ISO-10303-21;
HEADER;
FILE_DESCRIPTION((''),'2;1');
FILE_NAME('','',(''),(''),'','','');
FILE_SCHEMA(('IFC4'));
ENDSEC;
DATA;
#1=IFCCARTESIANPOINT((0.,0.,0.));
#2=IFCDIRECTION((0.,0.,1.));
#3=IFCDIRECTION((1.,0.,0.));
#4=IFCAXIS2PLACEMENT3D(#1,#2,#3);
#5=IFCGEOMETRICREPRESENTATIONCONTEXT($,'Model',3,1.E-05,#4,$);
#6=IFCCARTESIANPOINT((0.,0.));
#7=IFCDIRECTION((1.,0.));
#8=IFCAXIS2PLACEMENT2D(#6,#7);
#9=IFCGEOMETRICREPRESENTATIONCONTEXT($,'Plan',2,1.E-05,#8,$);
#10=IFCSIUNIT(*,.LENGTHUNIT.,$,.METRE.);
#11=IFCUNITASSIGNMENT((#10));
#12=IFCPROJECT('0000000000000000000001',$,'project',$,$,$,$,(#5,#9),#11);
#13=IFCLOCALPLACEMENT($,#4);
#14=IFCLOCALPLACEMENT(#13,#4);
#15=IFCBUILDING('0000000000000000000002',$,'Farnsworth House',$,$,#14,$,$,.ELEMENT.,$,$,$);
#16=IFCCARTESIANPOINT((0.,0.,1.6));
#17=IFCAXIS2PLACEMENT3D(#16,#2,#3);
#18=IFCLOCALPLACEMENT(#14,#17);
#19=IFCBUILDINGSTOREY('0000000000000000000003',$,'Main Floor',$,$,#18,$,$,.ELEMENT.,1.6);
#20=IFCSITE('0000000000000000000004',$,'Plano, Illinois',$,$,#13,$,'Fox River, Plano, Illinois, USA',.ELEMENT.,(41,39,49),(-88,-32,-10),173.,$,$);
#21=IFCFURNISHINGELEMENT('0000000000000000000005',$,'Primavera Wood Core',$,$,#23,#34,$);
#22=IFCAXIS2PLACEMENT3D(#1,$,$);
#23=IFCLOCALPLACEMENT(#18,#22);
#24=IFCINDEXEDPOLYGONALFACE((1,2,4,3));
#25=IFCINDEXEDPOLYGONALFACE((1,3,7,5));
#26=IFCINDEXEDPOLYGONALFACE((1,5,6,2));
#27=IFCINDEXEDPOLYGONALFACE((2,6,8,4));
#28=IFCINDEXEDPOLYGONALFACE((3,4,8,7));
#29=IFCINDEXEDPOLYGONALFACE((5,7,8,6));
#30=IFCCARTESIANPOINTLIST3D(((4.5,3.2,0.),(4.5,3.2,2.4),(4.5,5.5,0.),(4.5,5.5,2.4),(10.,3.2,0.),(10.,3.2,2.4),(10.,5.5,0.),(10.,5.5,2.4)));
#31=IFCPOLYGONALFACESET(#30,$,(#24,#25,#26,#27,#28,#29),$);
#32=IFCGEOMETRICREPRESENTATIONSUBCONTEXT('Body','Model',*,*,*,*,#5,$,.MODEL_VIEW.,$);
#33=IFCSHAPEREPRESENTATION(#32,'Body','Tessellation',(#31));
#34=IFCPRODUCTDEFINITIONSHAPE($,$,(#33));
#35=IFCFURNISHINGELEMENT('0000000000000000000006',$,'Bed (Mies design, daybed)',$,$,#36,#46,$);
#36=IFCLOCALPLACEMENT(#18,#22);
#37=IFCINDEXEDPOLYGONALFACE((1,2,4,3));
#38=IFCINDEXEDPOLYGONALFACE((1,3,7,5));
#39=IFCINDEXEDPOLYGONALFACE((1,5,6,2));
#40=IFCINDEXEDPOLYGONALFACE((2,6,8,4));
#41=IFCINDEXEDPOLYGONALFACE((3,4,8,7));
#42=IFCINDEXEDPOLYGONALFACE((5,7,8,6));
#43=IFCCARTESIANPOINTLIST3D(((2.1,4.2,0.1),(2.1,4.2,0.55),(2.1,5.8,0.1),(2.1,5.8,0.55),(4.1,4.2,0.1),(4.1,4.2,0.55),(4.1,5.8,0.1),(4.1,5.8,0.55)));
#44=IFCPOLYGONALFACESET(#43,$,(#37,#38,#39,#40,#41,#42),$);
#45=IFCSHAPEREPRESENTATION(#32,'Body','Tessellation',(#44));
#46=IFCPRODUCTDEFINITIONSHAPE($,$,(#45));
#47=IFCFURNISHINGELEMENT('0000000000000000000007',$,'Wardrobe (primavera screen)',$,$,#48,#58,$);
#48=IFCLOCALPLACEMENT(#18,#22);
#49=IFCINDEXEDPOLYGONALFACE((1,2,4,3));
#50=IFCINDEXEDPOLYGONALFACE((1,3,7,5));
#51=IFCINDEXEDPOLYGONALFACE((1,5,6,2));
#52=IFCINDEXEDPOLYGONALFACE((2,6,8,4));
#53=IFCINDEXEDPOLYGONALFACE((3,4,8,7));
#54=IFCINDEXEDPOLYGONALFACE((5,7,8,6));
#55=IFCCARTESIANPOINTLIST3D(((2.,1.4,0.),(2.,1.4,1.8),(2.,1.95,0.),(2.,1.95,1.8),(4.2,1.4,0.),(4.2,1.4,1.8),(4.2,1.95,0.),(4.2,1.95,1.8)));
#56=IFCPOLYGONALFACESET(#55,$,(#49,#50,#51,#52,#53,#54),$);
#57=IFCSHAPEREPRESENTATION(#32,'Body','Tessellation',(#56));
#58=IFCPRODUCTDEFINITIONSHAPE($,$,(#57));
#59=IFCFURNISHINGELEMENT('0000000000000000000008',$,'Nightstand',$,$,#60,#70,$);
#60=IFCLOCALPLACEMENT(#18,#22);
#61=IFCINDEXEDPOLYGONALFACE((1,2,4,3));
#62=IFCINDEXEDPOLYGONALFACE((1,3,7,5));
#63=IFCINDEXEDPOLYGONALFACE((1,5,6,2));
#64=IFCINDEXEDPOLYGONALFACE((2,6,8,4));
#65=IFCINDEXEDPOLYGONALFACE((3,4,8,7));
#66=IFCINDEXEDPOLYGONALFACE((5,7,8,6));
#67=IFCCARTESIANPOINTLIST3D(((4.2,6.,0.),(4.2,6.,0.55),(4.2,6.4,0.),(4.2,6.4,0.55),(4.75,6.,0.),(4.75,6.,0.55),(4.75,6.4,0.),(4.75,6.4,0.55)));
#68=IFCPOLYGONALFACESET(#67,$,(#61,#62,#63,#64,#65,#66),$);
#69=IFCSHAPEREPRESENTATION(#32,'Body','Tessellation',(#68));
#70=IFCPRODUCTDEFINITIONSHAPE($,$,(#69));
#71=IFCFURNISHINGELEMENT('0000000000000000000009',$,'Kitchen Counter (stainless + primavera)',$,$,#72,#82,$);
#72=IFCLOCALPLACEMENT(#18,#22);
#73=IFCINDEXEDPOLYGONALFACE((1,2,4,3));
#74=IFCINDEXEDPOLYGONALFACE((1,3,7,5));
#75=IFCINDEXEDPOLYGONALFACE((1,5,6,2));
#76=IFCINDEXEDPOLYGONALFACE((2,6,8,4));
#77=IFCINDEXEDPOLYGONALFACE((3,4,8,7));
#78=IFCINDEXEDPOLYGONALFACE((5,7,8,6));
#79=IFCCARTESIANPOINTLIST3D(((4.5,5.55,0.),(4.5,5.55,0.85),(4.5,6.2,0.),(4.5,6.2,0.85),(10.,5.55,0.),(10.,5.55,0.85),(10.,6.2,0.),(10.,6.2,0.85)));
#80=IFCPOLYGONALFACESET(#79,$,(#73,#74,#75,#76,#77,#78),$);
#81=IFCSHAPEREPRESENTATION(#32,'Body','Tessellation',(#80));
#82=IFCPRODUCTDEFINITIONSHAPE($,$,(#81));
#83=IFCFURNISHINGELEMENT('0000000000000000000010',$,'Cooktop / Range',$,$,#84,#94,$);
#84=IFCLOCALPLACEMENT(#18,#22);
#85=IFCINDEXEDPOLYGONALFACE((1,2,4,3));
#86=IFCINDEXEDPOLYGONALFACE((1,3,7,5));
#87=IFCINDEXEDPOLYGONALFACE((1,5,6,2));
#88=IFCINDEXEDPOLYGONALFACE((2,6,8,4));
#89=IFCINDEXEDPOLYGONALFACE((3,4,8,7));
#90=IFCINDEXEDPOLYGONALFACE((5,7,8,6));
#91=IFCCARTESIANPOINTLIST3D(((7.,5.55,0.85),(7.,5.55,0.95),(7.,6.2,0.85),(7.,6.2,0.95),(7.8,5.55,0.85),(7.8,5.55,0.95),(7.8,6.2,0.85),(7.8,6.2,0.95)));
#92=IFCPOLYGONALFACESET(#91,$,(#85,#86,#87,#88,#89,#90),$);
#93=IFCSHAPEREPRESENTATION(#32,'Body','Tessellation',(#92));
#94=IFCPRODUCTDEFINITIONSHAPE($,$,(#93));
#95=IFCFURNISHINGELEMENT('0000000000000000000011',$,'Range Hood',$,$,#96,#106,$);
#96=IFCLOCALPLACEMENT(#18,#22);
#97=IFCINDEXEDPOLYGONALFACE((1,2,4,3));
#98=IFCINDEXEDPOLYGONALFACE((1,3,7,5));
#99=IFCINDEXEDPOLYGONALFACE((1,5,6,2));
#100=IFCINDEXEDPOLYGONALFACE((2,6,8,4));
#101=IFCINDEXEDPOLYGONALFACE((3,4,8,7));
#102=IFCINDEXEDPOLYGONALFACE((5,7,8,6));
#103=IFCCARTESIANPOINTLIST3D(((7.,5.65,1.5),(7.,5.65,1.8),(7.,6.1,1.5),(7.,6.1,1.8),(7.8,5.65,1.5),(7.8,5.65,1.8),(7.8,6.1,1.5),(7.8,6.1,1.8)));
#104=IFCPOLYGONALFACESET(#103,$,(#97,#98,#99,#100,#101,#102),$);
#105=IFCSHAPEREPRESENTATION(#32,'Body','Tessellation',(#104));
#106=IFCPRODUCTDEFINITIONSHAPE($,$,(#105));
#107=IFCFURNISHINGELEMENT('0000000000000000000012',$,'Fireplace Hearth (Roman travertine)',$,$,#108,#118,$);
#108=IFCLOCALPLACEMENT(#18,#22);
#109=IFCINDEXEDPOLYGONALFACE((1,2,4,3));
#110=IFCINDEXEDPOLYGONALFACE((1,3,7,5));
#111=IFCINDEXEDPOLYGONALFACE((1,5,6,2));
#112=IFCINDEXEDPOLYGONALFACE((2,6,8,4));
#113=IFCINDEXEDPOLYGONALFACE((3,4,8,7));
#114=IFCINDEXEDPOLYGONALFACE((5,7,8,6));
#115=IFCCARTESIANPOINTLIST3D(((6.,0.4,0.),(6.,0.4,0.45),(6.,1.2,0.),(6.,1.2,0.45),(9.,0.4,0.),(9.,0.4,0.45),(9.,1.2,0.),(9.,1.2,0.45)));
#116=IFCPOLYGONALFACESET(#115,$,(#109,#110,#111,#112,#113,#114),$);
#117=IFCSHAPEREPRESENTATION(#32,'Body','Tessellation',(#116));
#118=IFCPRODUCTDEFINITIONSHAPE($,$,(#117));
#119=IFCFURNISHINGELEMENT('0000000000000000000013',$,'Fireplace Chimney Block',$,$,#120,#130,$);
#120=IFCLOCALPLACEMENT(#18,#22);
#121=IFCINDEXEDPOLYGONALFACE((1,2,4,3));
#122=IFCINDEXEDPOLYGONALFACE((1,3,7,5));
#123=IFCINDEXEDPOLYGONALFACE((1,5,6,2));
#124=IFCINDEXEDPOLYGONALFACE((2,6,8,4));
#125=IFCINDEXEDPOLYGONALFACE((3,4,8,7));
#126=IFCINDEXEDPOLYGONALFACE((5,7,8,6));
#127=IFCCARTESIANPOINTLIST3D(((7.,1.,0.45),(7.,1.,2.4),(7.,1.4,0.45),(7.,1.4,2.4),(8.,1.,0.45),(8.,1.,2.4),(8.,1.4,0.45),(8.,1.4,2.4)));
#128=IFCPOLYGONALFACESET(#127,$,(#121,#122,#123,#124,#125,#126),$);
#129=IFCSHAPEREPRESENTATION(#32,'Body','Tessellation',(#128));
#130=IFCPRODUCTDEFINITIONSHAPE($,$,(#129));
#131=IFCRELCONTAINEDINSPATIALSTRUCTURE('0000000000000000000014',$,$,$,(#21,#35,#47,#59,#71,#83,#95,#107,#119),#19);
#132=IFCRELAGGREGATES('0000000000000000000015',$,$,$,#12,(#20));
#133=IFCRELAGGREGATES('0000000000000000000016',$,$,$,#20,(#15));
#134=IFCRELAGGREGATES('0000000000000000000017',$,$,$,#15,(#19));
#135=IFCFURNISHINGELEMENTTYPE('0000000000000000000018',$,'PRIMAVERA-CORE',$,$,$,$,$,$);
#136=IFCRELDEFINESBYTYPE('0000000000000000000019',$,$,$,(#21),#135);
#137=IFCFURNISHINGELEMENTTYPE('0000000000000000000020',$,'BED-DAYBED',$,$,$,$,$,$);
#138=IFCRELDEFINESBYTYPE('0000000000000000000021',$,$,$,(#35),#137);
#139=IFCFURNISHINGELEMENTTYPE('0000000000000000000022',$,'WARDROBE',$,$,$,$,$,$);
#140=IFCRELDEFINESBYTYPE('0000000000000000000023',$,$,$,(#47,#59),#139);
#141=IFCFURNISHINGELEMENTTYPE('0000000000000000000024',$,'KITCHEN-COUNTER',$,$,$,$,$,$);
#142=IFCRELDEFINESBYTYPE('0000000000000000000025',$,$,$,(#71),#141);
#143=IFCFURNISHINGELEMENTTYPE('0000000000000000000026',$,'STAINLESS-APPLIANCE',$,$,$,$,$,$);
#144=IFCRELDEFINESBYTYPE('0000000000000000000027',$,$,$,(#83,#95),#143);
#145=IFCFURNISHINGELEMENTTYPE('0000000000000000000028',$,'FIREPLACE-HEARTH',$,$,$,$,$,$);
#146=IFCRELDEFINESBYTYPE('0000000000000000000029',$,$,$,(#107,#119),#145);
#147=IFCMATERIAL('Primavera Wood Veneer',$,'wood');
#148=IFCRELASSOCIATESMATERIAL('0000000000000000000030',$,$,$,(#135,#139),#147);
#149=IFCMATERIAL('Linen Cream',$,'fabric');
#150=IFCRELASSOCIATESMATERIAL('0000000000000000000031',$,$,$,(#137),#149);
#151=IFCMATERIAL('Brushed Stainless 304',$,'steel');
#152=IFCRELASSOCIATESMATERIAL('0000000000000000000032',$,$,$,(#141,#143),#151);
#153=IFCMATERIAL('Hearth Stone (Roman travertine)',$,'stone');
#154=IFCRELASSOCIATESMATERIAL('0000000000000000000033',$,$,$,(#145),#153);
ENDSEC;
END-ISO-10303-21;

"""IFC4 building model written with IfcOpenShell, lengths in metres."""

from ifc_helpers import new_model, si_unit, frame, origin_with_axes, origin_2d_with_axis, place, context, subcontext, project, spatial, rectangle, extrude, material, type_object, element, save


model = new_model("IFC4")

# Units and contexts
model_context = context("Model", 3, precision=1e-05, world=origin_with_axes())
plan_context = context("Plan", 2, precision=1e-05, world=origin_2d_with_axis())
body_context = subcontext(model_context, "Body", "Model", "MODEL_VIEW")
ifc_project = project(units=[si_unit("LENGTHUNIT", "METRE")], contexts=[model_context, plan_context])

# Site, building, storey
site_placement = place(None, origin_with_axes())
site = spatial("IfcSite", under=ifc_project, at=site_placement, Name="Plano, Illinois", LongName="Fox River, Plano, Illinois, USA", CompositionType="ELEMENT", RefLatitude=(41, 39, 49), RefLongitude=(-88, -32, -10), RefElevation=173.0)
building_placement = place(site_placement, origin_with_axes())
building = spatial("IfcBuilding", under=site, at=building_placement, Name="Farnsworth House", CompositionType="ELEMENT")
storey_placement = place(building_placement, frame((0.0, 0.0, 1.6), z_axis=(0.0, 0.0, 1.0), x_axis=(1.0, 0.0, 0.0)))
storey = spatial("IfcBuildingStorey", under=building, at=storey_placement, Name="Main Floor", CompositionType="ELEMENT", Elevation=1.6)

# Shared definitions
ifc_material_1 = material(Name="Brushed Stainless 304", Category="steel")

# Furnishing elements
ifc_material_2 = material(Name="Primavera Wood Veneer", Category="wood")
furnishing_element_type_1 = type_object("IfcFurnishingElementType", Name="PRIMAVERA-CORE", material=ifc_material_2)
furnishing_1_placement = place(storey_placement, frame((4.5, 3.2, 0.0), z_axis=(0.0, 0.0, 1.0), x_axis=(1.0, 0.0, 0.0)))
element("IfcFurnishingElement", 1, at=furnishing_1_placement, inside=storey, type_object=furnishing_element_type_1, Name="Primavera Wood Core", context=body_context, shape_type="SweptSolid", body=[
    extrude(rectangle(XDim=5.5, YDim=2.3, at=origin_2d_with_axis()), frame((2.75, 1.15, 0.0), z_axis=(0.0, 0.0, 1.0), x_axis=(1.0, 0.0, 0.0)), (0.0, 0.0, 1.0), 2.4),
])
ifc_material_3 = material(Name="Linen Cream", Category="fabric")
furnishing_element_type_2 = type_object("IfcFurnishingElementType", Name="BED-DAYBED", material=ifc_material_3)
furnishing_2_placement = place(storey_placement, frame((2.1, 4.2, 0.1), z_axis=(0.0, 0.0, 1.0), x_axis=(1.0, 0.0, 0.0)))
element("IfcFurnishingElement", 2, at=furnishing_2_placement, inside=storey, type_object=furnishing_element_type_2, Name="Bed (Mies design, daybed)", context=body_context, shape_type="SweptSolid", body=[
    extrude(rectangle(XDim=2.0, YDim=1.6, at=origin_2d_with_axis()), frame((1.0, 0.8, 0.0), z_axis=(0.0, 0.0, 1.0), x_axis=(1.0, 0.0, 0.0)), (0.0, 0.0, 1.0), 0.45),
])
furnishing_element_type_3 = type_object("IfcFurnishingElementType", Name="WARDROBE", material=ifc_material_2)
furnishing_3_placement = place(storey_placement, frame((2.0, 1.4, 0.0), z_axis=(0.0, 0.0, 1.0), x_axis=(1.0, 0.0, 0.0)))
element("IfcFurnishingElement", 3, at=furnishing_3_placement, inside=storey, type_object=furnishing_element_type_3, Name="Wardrobe (primavera screen)", context=body_context, shape_type="SweptSolid", body=[
    extrude(rectangle(XDim=2.2, YDim=0.55, at=origin_2d_with_axis()), frame((1.1, 0.275, 0.0), z_axis=(0.0, 0.0, 1.0), x_axis=(1.0, 0.0, 0.0)), (0.0, 0.0, 1.0), 1.8),
])
furnishing_4_placement = place(storey_placement, frame((4.2, 6.0, 0.0), z_axis=(0.0, 0.0, 1.0), x_axis=(1.0, 0.0, 0.0)))
element("IfcFurnishingElement", 4, at=furnishing_4_placement, inside=storey, type_object=furnishing_element_type_3, Name="Nightstand", context=body_context, shape_type="SweptSolid", body=[
    extrude(rectangle(XDim=0.55, YDim=0.4, at=origin_2d_with_axis()), frame((0.275, 0.2, 0.0), z_axis=(0.0, 0.0, 1.0), x_axis=(1.0, 0.0, 0.0)), (0.0, 0.0, 1.0), 0.55),
])
furnishing_element_type_4 = type_object("IfcFurnishingElementType", Name="KITCHEN-COUNTER", material=ifc_material_1)
furnishing_5_placement = place(storey_placement, frame((4.5, 5.55, 0.0), z_axis=(0.0, 0.0, 1.0), x_axis=(1.0, 0.0, 0.0)))
element("IfcFurnishingElement", 5, at=furnishing_5_placement, inside=storey, type_object=furnishing_element_type_4, Name="Kitchen Counter (stainless + primavera)", context=body_context, shape_type="SweptSolid", body=[
    extrude(rectangle(XDim=5.5, YDim=0.65, at=origin_2d_with_axis()), frame((2.75, 0.325, 0.0), z_axis=(0.0, 0.0, 1.0), x_axis=(1.0, 0.0, 0.0)), (0.0, 0.0, 1.0), 0.85),
])
furnishing_element_type_5 = type_object("IfcFurnishingElementType", Name="STAINLESS-APPLIANCE", material=ifc_material_1)
furnishing_6_placement = place(storey_placement, frame((7.0, 5.55, 0.85), z_axis=(0.0, 0.0, 1.0), x_axis=(1.0, 0.0, 0.0)))
element("IfcFurnishingElement", 6, at=furnishing_6_placement, inside=storey, type_object=furnishing_element_type_5, Name="Cooktop / Range", context=body_context, shape_type="SweptSolid", body=[
    extrude(rectangle(XDim=0.8, YDim=0.65, at=origin_2d_with_axis()), frame((0.4, 0.325, 0.0), z_axis=(0.0, 0.0, 1.0), x_axis=(1.0, 0.0, 0.0)), (0.0, 0.0, 1.0), 0.1),
])
furnishing_7_placement = place(storey_placement, frame((7.0, 5.65, 1.5), z_axis=(0.0, 0.0, 1.0), x_axis=(1.0, 0.0, 0.0)))
element("IfcFurnishingElement", 7, at=furnishing_7_placement, inside=storey, type_object=furnishing_element_type_5, Name="Range Hood", context=body_context, shape_type="SweptSolid", body=[
    extrude(rectangle(XDim=0.8, YDim=0.45, at=origin_2d_with_axis()), frame((0.4, 0.225, 0.0), z_axis=(0.0, 0.0, 1.0), x_axis=(1.0, 0.0, 0.0)), (0.0, 0.0, 1.0), 0.3),
])
ifc_material_4 = material(Name="Hearth Stone (Roman travertine)", Category="stone")
furnishing_element_type_6 = type_object("IfcFurnishingElementType", Name="FIREPLACE-HEARTH", material=ifc_material_4)
furnishing_8_placement = place(storey_placement, frame((6.0, 0.4, 0.0), z_axis=(0.0, 0.0, 1.0), x_axis=(1.0, 0.0, 0.0)))
element("IfcFurnishingElement", 8, at=furnishing_8_placement, inside=storey, type_object=furnishing_element_type_6, Name="Fireplace Hearth (Roman travertine)", context=body_context, shape_type="SweptSolid", body=[
    extrude(rectangle(XDim=3.0, YDim=0.8, at=origin_2d_with_axis()), frame((1.5, 0.4, 0.0), z_axis=(0.0, 0.0, 1.0), x_axis=(1.0, 0.0, 0.0)), (0.0, 0.0, 1.0), 0.45),
])
furnishing_9_placement = place(storey_placement, frame((7.0, 1.0, 0.45), z_axis=(0.0, 0.0, 1.0), x_axis=(1.0, 0.0, 0.0)))
element("IfcFurnishingElement", 9, at=furnishing_9_placement, inside=storey, type_object=furnishing_element_type_6, Name="Fireplace Chimney Block", context=body_context, shape_type="SweptSolid", body=[
    extrude(rectangle(XDim=1.0, YDim=0.4, at=origin_2d_with_axis()), frame((0.5, 0.2, 0.0), z_axis=(0.0, 0.0, 1.0), x_axis=(1.0, 0.0, 0.0)), (0.0, 0.0, 1.0), 1.95),
])

save(model, "model.ifc")
